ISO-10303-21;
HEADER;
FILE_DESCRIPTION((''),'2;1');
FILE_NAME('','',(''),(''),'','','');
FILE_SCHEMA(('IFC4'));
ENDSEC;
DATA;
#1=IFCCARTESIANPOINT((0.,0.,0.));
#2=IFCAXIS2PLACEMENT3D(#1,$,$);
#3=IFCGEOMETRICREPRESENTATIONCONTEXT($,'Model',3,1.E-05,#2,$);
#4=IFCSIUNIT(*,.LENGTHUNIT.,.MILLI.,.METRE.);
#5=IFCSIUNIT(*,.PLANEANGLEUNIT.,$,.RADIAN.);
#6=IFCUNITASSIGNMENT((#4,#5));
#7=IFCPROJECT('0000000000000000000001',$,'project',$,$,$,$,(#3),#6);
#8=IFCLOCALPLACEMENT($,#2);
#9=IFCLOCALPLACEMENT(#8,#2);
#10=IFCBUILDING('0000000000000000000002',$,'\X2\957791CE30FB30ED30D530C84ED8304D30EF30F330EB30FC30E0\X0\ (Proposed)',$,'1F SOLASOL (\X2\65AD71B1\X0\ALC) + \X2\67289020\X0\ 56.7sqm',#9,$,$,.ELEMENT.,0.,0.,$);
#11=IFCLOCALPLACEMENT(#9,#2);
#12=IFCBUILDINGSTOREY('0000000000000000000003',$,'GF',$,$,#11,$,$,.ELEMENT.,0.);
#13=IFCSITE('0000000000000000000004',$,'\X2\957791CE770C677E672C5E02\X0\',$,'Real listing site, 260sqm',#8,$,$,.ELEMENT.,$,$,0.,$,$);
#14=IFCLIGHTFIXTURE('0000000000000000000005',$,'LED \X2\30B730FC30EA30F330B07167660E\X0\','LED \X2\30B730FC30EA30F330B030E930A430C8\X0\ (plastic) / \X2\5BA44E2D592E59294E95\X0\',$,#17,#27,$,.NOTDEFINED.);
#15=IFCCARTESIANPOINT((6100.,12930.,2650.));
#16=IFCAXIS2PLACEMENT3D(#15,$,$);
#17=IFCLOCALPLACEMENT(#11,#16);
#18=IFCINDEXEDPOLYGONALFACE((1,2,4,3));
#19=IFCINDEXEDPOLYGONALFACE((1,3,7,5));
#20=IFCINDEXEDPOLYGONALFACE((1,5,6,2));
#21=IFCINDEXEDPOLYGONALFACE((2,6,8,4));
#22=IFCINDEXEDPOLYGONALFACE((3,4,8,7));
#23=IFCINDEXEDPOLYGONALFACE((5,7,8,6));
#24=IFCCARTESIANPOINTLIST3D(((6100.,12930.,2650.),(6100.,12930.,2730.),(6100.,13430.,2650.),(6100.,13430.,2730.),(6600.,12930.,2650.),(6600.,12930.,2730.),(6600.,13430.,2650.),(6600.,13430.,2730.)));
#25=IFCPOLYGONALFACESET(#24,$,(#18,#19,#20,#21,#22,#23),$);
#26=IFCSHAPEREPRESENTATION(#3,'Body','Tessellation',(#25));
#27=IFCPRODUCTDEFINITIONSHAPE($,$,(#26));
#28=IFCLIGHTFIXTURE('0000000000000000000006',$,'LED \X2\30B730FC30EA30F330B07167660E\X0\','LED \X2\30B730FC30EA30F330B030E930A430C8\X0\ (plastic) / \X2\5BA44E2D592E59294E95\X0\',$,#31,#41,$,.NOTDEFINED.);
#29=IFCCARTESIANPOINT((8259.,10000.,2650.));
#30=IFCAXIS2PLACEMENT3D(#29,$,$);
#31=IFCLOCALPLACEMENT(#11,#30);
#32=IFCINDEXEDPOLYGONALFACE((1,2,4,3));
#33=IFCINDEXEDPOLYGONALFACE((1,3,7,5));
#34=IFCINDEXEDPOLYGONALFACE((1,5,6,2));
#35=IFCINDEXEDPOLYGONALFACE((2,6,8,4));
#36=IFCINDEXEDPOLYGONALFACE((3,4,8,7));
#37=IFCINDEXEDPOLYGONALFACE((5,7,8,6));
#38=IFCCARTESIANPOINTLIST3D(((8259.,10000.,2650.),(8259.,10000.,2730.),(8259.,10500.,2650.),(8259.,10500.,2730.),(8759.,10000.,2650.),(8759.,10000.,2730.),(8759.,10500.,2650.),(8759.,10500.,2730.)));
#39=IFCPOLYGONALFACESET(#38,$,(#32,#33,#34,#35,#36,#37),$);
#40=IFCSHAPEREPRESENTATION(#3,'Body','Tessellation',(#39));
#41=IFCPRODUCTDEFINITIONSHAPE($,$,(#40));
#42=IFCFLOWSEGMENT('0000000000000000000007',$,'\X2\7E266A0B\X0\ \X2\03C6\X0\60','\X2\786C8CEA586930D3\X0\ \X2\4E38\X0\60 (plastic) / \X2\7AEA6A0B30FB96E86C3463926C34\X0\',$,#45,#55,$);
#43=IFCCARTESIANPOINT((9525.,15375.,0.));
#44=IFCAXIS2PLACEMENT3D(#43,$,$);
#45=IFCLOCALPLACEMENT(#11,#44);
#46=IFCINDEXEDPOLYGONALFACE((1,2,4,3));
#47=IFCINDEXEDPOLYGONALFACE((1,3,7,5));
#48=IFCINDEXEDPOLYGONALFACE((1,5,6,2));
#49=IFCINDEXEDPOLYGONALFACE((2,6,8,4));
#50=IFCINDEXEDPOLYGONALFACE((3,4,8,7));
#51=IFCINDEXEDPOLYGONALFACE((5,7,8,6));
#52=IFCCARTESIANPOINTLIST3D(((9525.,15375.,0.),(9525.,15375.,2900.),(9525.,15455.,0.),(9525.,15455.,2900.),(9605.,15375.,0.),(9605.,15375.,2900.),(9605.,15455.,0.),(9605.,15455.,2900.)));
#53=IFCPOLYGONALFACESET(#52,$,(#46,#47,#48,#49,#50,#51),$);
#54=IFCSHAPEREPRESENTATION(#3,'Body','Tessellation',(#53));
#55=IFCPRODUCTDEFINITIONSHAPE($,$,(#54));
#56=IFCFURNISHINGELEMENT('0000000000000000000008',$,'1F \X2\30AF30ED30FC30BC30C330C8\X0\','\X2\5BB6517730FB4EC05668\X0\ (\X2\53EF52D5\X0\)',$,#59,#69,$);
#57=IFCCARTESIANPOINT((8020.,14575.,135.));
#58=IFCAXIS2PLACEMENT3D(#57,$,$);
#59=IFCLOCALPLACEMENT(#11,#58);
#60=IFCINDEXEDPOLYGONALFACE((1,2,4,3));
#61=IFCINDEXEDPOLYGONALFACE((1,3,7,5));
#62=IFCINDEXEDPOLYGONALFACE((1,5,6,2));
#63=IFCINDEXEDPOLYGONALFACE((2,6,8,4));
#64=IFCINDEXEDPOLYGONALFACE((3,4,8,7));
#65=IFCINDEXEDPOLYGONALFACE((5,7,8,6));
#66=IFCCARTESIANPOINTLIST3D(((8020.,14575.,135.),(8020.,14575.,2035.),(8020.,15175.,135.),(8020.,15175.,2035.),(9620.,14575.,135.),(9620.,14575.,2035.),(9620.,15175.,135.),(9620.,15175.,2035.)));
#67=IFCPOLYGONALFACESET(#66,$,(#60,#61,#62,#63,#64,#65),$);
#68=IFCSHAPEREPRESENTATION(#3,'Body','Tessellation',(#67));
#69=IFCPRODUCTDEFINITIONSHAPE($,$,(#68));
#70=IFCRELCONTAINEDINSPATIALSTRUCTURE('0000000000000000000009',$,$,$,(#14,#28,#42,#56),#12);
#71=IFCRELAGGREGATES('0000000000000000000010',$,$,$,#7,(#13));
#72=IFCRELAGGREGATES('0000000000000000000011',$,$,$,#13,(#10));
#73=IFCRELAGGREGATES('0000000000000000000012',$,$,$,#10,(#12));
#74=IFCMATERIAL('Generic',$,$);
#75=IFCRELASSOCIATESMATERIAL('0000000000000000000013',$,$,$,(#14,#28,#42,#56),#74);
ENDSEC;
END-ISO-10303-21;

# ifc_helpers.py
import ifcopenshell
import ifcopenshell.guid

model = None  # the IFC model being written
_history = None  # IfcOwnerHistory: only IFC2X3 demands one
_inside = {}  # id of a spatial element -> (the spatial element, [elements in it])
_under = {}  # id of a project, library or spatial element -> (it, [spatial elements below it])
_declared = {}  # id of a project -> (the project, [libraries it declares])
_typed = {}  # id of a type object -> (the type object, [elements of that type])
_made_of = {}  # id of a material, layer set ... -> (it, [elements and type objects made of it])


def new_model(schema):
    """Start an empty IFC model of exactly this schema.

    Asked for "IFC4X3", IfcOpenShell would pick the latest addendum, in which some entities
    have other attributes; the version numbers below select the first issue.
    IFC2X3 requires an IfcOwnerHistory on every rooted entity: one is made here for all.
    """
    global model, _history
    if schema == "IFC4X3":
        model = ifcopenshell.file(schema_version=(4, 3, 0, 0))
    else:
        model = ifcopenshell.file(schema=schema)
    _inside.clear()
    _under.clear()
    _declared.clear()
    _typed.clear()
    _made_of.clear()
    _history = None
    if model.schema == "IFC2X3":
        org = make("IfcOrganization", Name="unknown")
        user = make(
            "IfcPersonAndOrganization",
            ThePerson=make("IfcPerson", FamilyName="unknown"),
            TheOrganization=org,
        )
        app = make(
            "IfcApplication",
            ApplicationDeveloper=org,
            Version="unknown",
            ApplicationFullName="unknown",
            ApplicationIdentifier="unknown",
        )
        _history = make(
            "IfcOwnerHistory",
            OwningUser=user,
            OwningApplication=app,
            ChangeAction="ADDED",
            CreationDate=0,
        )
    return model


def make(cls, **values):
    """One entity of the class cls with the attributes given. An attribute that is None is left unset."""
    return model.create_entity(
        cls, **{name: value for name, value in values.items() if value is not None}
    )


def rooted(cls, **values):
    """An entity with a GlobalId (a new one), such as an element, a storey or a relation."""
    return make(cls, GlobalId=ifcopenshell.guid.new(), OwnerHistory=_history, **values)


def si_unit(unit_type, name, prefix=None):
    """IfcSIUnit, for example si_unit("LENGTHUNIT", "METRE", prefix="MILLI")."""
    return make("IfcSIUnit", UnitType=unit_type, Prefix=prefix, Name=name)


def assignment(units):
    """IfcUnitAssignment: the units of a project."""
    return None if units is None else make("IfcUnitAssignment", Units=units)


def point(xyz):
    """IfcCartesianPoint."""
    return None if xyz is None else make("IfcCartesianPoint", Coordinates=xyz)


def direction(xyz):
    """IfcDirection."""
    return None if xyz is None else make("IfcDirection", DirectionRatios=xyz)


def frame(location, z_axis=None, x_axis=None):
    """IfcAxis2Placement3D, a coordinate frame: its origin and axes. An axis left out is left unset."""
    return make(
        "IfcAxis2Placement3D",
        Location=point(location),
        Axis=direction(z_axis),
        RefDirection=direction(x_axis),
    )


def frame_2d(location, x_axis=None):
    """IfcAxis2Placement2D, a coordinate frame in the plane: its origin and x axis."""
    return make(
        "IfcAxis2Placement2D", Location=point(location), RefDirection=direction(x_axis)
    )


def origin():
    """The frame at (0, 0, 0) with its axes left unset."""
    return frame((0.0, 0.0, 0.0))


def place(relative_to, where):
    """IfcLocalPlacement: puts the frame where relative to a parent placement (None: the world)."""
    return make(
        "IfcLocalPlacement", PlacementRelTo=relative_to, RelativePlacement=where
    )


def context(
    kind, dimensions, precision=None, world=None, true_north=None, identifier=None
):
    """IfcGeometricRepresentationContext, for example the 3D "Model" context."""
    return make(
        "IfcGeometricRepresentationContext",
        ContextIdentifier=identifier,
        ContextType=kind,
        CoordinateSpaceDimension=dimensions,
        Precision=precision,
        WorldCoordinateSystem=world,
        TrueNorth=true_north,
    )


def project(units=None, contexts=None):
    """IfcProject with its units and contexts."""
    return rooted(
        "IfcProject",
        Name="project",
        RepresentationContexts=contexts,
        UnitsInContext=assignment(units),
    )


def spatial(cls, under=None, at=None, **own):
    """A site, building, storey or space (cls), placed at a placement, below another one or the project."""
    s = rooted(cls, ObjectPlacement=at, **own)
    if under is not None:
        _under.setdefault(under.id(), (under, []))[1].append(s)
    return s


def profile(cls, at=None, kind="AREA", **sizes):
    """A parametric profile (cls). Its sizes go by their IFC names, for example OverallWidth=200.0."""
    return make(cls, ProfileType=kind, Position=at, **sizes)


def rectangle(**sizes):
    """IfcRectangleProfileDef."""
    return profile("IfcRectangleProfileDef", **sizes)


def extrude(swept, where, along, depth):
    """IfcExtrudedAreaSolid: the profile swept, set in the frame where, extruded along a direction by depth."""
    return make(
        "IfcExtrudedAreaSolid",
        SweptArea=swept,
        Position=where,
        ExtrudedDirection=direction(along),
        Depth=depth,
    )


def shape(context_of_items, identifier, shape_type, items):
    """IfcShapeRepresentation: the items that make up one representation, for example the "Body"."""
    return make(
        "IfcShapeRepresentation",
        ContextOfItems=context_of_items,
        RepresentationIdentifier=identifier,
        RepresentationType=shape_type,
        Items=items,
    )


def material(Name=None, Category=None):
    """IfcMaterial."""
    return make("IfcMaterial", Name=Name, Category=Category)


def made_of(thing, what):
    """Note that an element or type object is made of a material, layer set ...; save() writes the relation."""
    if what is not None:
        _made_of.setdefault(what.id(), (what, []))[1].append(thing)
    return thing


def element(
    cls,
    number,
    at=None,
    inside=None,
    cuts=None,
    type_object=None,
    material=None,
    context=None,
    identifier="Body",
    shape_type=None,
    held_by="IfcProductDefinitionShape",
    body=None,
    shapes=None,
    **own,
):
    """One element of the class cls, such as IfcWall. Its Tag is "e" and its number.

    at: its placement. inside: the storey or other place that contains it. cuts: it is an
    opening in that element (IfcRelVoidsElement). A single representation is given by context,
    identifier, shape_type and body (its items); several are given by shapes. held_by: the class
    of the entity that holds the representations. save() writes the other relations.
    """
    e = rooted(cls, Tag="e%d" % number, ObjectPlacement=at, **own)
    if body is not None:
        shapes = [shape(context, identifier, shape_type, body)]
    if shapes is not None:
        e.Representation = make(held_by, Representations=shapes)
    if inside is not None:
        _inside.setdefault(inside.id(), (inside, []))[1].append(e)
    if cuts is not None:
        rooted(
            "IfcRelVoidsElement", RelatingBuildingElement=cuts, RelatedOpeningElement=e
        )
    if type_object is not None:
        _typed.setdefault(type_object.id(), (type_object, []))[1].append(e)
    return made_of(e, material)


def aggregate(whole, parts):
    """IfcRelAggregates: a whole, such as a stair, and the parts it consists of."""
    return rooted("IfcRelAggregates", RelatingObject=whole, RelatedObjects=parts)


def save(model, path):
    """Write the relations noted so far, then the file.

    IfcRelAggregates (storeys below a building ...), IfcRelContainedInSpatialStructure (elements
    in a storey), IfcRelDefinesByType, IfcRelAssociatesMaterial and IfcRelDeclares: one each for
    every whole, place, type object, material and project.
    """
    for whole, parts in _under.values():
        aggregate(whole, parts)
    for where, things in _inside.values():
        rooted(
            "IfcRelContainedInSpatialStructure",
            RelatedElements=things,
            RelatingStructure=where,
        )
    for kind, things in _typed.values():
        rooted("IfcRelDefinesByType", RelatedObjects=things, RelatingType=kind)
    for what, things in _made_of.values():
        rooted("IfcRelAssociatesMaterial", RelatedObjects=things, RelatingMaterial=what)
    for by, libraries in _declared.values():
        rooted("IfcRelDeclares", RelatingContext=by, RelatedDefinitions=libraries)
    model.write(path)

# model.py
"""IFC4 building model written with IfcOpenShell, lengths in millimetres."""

from ifc_helpers import new_model, si_unit, frame, frame_2d, origin, place, context, project, spatial, rectangle, extrude, material, element, save


model = new_model("IFC4")

# Units and contexts
model_context = context("Model", 3, precision=1e-05, world=origin())
ifc_project = project(units=[si_unit("LENGTHUNIT", "METRE", prefix="MILLI"), si_unit("PLANEANGLEUNIT", "RADIAN")], contexts=[model_context])

# Site, building, storey
site_placement = place(None, origin())
site = spatial("IfcSite", under=ifc_project, at=site_placement, Name="長野県松本市", ObjectType="Real listing site, 260sqm", CompositionType="ELEMENT", RefElevation=0.0)
building_placement = place(site_placement, origin())
building = spatial("IfcBuilding", under=site, at=building_placement, Name="長野・ロフト付きワンルーム (Proposed)", ObjectType="1F SOLASOL (断熱ALC) + 木造 56.7sqm", CompositionType="ELEMENT", ElevationOfRefHeight=0.0, ElevationOfTerrain=0.0)
storey_placement = place(building_placement, origin())
storey = spatial("IfcBuildingStorey", under=building, at=storey_placement, Name="GF", CompositionType="ELEMENT", Elevation=0.0)

# Shared definitions
ifc_material_1 = material(Name="Generic")

# Light fixtures
light_fixture_1_placement = place(storey_placement, frame((6100.0, 12930.0, 2650.0)))
element("IfcLightFixture", 1, at=light_fixture_1_placement, inside=storey, material=ifc_material_1, Name="LED シーリング照明", Description="LED シーリングライト (plastic) / 室中央天井", PredefinedType="NOTDEFINED", context=model_context, shape_type="SweptSolid", body=[
    extrude(rectangle(XDim=500.0, YDim=500.0, at=frame_2d((250.0, 250.0))), frame((6100.0, 12930.0, 2650.0)), (0.0, 0.0, 1.0), 80.0),
])
light_fixture_2_placement = place(storey_placement, frame((8259.0, 10000.0, 2650.0)))
element("IfcLightFixture", 2, at=light_fixture_2_placement, inside=storey, material=ifc_material_1, Name="LED シーリング照明", Description="LED シーリングライト (plastic) / 室中央天井", PredefinedType="NOTDEFINED", context=model_context, shape_type="SweptSolid", body=[
    extrude(rectangle(XDim=500.0, YDim=500.0, at=frame_2d((250.0, 250.0))), frame((8259.0, 10000.0, 2650.0)), (0.0, 0.0, 1.0), 80.0),
])

# Flow segment
flow_segment_placement = place(storey_placement, frame((9525.0, 15375.0, 0.0)))
element("IfcFlowSegment", 3, at=flow_segment_placement, inside=storey, material=ifc_material_1, Name="縦樋 φ60", Description="硬質塩ビ 丸60 (plastic) / 竪樋・雨水排水", context=model_context, shape_type="SweptSolid", body=[
    extrude(rectangle(XDim=80.0, YDim=80.0, at=frame_2d((40.0, 40.0))), frame((9525.0, 15375.0, 0.0)), (0.0, 0.0, 1.0), 2900.0),
])

# Furnishing element
furnishing_placement = place(storey_placement, frame((8020.0, 14575.0, 135.0)))
element("IfcFurnishingElement", 4, at=furnishing_placement, inside=storey, material=ifc_material_1, Name="1F クローゼット", Description="家具・什器 (可動)", context=model_context, shape_type="SweptSolid", body=[
    extrude(rectangle(XDim=1600.0, YDim=600.0, at=frame_2d((800.0, 300.0))), frame((8020.0, 14575.0, 135.0)), (0.0, 0.0, 1.0), 1900.0),
])

save(model, "model.ifc")
